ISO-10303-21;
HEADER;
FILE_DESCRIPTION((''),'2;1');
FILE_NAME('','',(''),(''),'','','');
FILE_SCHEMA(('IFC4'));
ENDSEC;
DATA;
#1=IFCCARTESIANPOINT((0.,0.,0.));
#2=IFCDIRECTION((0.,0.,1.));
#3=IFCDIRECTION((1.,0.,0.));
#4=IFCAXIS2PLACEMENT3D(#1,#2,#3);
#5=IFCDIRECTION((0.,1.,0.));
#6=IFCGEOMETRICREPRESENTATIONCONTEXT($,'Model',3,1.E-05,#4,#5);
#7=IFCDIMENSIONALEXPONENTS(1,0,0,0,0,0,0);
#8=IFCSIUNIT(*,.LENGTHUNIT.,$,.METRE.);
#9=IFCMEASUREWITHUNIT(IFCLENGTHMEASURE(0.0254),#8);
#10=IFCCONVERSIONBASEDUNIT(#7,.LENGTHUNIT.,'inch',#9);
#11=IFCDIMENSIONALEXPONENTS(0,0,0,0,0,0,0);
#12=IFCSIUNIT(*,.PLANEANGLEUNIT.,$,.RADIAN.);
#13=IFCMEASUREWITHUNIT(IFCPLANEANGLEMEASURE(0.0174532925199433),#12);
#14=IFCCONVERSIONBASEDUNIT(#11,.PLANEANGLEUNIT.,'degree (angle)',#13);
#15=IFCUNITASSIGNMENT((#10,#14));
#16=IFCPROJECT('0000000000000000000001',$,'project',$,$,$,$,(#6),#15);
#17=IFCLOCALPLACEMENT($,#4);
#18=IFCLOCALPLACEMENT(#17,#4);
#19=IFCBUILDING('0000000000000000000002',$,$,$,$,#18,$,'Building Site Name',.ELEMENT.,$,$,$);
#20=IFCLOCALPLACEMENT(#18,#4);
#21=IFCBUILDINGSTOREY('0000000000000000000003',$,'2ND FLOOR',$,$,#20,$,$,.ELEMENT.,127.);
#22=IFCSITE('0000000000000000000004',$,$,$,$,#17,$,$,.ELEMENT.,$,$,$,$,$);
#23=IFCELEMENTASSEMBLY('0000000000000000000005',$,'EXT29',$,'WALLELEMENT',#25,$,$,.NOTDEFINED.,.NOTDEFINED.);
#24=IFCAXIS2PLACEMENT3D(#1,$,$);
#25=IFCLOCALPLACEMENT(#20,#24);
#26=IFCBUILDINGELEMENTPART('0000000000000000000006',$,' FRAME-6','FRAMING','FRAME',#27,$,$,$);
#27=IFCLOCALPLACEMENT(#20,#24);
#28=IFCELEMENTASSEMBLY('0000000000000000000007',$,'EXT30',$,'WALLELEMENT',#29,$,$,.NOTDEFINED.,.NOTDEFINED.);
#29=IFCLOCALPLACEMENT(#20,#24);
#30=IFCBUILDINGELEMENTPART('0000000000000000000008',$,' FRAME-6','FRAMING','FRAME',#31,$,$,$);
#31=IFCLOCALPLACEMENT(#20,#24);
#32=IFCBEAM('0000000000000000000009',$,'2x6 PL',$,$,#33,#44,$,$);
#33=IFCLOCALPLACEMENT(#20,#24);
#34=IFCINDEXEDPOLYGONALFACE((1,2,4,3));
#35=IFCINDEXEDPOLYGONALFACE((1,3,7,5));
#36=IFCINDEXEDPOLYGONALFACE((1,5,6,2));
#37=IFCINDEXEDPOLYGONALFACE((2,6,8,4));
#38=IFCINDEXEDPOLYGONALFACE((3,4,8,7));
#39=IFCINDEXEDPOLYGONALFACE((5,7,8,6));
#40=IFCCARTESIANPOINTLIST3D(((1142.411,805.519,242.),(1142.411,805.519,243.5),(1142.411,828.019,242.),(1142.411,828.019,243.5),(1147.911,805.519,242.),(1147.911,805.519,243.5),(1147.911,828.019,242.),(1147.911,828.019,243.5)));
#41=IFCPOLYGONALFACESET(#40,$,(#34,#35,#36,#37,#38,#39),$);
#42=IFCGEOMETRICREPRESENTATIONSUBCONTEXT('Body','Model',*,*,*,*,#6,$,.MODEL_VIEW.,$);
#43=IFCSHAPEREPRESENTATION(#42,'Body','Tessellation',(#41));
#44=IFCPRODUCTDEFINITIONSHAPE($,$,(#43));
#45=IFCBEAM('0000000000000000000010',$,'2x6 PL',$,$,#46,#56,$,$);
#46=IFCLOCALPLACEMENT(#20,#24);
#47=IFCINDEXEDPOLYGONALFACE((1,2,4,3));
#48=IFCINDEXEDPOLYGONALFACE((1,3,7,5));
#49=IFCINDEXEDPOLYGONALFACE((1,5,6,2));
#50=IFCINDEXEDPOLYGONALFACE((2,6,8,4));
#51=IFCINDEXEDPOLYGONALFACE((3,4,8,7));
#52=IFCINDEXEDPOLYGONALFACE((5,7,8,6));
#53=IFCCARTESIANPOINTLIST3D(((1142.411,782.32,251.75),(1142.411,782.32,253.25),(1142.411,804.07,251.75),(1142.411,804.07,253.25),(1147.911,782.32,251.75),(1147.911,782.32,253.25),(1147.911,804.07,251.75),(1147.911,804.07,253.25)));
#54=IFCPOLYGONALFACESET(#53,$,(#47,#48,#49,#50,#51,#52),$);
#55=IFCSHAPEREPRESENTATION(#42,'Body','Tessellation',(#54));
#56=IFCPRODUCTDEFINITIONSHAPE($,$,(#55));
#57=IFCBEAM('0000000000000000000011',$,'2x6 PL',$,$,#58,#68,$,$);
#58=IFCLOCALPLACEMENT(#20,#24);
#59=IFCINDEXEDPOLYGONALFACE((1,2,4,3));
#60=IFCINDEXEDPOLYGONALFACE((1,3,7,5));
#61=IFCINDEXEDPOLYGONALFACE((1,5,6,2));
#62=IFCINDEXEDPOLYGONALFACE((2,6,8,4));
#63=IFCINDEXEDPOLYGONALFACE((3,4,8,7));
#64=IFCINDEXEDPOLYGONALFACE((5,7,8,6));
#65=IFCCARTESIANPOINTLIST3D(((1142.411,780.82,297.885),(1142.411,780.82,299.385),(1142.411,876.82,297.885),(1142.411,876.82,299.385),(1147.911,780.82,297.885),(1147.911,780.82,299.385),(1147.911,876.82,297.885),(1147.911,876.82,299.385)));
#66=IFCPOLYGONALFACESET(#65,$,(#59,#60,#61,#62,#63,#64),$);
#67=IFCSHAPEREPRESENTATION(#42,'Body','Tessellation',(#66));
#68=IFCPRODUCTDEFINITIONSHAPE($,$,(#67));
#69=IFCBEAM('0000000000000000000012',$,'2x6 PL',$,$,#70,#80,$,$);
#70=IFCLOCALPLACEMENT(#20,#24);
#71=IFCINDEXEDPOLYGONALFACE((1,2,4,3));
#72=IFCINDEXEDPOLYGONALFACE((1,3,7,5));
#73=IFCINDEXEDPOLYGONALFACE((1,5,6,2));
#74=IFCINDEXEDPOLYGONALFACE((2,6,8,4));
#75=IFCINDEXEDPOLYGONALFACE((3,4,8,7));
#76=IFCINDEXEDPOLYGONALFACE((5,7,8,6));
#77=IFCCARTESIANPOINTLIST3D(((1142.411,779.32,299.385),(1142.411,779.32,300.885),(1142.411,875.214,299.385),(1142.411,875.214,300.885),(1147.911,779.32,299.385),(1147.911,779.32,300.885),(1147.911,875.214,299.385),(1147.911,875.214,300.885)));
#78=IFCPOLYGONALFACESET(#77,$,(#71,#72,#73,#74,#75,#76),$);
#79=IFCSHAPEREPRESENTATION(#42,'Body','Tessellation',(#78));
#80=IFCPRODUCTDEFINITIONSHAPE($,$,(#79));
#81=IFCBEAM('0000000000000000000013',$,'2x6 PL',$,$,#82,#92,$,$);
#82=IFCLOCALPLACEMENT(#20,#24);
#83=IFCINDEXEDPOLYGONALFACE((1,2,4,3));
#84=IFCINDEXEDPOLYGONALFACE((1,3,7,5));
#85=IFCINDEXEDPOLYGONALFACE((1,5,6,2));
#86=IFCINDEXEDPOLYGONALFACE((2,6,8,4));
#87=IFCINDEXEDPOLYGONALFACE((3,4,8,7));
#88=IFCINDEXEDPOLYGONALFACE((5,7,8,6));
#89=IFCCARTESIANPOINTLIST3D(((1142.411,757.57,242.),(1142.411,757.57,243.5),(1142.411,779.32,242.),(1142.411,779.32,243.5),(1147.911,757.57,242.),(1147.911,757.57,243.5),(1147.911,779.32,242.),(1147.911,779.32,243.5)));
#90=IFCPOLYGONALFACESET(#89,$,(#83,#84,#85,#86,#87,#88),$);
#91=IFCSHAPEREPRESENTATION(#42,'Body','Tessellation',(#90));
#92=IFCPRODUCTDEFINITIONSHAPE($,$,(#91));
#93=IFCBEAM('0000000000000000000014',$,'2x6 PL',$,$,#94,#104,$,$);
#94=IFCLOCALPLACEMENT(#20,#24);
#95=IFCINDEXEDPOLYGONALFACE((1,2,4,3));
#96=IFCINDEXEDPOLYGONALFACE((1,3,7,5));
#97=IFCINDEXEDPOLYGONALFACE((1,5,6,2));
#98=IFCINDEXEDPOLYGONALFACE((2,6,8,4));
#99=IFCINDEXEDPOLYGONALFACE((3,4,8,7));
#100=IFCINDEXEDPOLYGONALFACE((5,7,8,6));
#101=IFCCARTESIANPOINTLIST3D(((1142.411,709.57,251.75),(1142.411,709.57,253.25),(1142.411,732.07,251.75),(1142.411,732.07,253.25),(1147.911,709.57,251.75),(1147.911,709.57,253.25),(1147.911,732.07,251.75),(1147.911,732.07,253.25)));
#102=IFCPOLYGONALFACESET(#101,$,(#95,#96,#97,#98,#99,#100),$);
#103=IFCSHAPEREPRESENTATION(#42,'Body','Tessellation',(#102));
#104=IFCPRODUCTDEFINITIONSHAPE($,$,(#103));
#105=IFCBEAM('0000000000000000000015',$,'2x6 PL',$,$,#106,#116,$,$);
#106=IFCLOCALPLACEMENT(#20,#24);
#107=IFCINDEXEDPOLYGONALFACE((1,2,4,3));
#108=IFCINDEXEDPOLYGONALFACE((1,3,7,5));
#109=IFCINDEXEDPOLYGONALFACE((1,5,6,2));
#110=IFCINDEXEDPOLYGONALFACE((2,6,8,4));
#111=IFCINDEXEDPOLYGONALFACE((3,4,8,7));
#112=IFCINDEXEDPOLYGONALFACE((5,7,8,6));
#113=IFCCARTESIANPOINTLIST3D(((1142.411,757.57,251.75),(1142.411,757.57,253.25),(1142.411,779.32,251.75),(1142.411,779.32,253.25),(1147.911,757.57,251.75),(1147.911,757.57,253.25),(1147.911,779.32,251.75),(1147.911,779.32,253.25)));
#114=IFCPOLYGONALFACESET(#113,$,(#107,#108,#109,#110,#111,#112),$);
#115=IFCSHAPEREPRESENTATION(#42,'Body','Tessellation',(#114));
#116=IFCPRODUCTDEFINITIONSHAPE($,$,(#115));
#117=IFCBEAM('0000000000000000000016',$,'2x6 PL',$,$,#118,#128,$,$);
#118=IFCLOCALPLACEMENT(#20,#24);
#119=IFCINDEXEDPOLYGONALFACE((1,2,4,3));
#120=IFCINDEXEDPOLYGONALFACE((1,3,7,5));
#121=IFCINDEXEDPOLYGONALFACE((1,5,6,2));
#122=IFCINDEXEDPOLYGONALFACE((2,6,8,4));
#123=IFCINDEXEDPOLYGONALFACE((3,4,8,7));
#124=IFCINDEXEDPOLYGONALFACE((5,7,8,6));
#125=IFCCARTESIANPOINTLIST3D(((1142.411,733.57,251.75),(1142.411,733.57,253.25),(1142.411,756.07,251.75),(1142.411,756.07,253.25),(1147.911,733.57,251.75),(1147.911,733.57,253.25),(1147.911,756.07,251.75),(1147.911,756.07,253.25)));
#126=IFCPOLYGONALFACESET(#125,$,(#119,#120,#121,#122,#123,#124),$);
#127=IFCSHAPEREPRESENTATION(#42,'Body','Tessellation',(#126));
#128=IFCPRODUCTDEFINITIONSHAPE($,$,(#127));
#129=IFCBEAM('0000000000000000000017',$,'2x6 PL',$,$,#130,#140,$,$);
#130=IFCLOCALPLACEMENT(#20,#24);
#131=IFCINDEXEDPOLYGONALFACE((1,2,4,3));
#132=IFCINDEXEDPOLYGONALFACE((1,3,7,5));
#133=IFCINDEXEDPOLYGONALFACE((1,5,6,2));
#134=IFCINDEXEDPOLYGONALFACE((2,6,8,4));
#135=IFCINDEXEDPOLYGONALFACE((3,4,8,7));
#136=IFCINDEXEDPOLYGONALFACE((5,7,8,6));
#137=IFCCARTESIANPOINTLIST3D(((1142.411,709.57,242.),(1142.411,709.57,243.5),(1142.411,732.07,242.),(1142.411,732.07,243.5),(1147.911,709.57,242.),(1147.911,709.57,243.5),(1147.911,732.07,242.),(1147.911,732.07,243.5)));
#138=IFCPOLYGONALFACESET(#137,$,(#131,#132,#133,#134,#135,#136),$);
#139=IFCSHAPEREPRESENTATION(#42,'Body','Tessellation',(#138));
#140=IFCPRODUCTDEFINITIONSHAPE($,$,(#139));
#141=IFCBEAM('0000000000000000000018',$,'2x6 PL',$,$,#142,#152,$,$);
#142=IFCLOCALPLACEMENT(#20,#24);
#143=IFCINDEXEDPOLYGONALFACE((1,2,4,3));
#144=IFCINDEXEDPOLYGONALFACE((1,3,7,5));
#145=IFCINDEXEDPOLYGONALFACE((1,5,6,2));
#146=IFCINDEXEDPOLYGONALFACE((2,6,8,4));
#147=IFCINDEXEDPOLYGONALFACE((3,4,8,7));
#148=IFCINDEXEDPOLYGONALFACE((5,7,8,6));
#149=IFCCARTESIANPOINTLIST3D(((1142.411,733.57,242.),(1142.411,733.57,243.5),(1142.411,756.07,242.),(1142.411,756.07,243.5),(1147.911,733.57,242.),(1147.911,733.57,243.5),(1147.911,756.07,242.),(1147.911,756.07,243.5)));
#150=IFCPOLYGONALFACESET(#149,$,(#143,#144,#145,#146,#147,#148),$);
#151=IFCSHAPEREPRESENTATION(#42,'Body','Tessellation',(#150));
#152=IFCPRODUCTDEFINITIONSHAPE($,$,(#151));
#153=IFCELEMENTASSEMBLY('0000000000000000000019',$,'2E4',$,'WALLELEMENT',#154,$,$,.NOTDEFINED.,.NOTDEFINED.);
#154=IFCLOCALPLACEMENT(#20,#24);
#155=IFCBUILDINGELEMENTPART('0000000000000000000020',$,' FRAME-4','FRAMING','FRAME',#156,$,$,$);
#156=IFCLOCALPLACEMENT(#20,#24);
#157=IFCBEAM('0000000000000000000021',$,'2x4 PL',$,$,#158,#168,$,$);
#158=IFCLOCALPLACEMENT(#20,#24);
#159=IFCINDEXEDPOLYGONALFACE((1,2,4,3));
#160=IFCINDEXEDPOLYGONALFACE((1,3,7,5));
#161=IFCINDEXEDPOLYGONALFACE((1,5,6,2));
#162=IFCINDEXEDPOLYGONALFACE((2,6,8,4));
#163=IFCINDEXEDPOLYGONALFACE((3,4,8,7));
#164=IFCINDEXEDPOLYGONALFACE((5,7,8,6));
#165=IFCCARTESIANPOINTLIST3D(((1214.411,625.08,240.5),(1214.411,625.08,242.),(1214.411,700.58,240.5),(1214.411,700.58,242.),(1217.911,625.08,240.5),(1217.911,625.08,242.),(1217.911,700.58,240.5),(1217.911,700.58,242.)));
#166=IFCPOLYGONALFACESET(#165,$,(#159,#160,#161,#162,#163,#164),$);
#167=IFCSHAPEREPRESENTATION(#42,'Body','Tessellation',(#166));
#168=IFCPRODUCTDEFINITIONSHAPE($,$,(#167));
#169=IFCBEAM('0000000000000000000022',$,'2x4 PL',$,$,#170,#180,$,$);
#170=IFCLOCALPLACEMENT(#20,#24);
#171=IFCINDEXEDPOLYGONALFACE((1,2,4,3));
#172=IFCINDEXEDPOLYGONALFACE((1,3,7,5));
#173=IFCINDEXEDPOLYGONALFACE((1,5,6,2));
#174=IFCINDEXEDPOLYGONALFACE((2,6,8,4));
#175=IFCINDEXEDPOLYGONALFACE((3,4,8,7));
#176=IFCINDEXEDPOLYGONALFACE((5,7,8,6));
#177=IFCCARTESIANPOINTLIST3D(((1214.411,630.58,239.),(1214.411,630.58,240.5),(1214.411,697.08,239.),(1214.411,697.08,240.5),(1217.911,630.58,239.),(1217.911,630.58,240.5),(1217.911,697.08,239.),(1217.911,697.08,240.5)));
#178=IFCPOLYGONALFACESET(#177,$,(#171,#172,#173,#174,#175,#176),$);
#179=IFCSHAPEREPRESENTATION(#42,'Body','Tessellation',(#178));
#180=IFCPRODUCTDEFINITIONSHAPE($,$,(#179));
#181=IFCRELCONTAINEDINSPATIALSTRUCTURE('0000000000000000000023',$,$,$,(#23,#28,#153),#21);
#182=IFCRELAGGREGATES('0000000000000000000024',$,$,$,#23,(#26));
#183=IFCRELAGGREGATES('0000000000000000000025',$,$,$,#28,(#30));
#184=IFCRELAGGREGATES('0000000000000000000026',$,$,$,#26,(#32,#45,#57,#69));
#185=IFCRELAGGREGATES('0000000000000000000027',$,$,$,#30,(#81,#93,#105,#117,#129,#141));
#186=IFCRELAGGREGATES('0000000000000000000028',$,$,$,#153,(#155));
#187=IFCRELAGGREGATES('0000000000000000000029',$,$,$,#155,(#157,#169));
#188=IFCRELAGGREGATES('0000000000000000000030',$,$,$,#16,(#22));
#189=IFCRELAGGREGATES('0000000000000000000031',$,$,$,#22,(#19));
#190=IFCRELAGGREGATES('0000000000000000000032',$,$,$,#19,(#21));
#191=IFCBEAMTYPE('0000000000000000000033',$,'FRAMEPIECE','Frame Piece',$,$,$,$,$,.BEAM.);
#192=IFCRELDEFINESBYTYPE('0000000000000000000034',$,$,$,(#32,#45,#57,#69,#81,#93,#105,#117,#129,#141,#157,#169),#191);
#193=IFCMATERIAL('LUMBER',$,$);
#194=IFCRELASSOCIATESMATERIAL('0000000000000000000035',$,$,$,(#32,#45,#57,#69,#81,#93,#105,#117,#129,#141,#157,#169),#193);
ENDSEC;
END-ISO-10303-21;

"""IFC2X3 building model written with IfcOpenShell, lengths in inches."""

from ifc_helpers import new_model, entity, si_unit, converted_unit, direction, frame, frame_2d, origin_with_axes, place, context, subcontext, project, spatial, rectangle, extrude, material, type_object, element, aggregate, save


model = new_model("IFC2X3")

# Units and contexts
model_context = context("Model", 3, precision=1e-05, world=origin_with_axes(), true_north=direction((0.0, 1.0, 0.0)))
body_context = subcontext(model_context, "Body", "Model", "MODEL_VIEW")
ifc_project = project(units=[converted_unit("LENGTHUNIT", "inch", entity("IfcLengthMeasure", 0.0254), si_unit("LENGTHUNIT", "METRE"), dimensions=[1, 0, 0, 0, 0, 0, 0]), converted_unit("PLANEANGLEUNIT", "degree (angle)", entity("IfcPlaneAngleMeasure", 0.0174532925199433), si_unit("PLANEANGLEUNIT", "RADIAN"), dimensions=[0, 0, 0, 0, 0, 0, 0])], contexts=[model_context])

# Site, building, storey
site_placement = place(None, origin_with_axes())
site = spatial("IfcSite", under=ifc_project, at=site_placement, CompositionType="ELEMENT")
building_placement = place(site_placement, origin_with_axes())
building = spatial("IfcBuilding", under=site, at=building_placement, LongName="Building Site Name", CompositionType="ELEMENT")
storey_placement = place(building_placement, origin_with_axes())
storey = spatial("IfcBuildingStorey", under=building, at=storey_placement, Name="2ND FLOOR", CompositionType="ELEMENT", Elevation=127.0)

# Element assembly, building element part
assembly_1_placement = place(storey_placement, origin_with_axes())
assembly_1 = element("IfcElementAssembly", 1, at=assembly_1_placement, inside=storey, Name="EXT29", ObjectType="WALLELEMENT", AssemblyPlace="NOTDEFINED", PredefinedType="NOTDEFINED")
building_element_part_1 = element("IfcBuildingElementPart", 2, Name=" FRAME-6", Description="FRAMING", ObjectType="FRAME")
aggregate(assembly_1, [building_element_part_1])
ifc_material = material(Name="LUMBER")
beam_type = type_object("IfcBeamType", Name="FRAMEPIECE", Description="Frame Piece", PredefinedType="BEAM")

# Element assembly, building element part
assembly_2_placement = place(storey_placement, origin_with_axes())
assembly_2 = element("IfcElementAssembly", 3, at=assembly_2_placement, inside=storey, Name="EXT30", ObjectType="WALLELEMENT", AssemblyPlace="NOTDEFINED", PredefinedType="NOTDEFINED")
building_element_part_2 = element("IfcBuildingElementPart", 4, Name=" FRAME-6", Description="FRAMING", ObjectType="FRAME")
aggregate(assembly_2, [building_element_part_2])

# Beams
beam_1_placement = place(assembly_1_placement, frame((1145.161, 805.519, 242.75), z_axis=(0.0, 1.0, 0.0), x_axis=(0.0, 0.0, -1.0)))
beam_1 = element("IfcBeam", 5, at=beam_1_placement, type_object=beam_type, material=ifc_material, Name="2x6 PL", context=body_context, shape_type="SweptSolid", body=[
    extrude(rectangle(XDim=1.5, YDim=5.5, at=frame_2d((0.0, 0.0), x_axis=(-1.0, 0.0))), origin_with_axes(), (0.0, 0.0, 1.0), 22.5),
])
beam_2_placement = place(assembly_1_placement, frame((1145.161, 782.32, 252.5), z_axis=(0.0, 1.0, 0.0), x_axis=(0.0, 0.0, -1.0)))
beam_2 = element("IfcBeam", 6, at=beam_2_placement, type_object=beam_type, material=ifc_material, Name="2x6 PL", context=body_context, shape_type="SweptSolid", body=[
    extrude(rectangle(XDim=1.5, YDim=5.5, at=frame_2d((0.0, 0.0), x_axis=(-1.0, 0.0))), origin_with_axes(), (0.0, 0.0, 1.0), 21.75),
])
beam_3_placement = place(assembly_1_placement, frame((1145.161, 780.82, 298.635), z_axis=(0.0, 1.0, 0.0), x_axis=(0.0, 0.0, -1.0)))
beam_3 = element("IfcBeam", 7, at=beam_3_placement, type_object=beam_type, material=ifc_material, Name="2x6 PL", context=body_context, shape_type="SweptSolid", body=[
    extrude(rectangle(XDim=1.5, YDim=5.5, at=frame_2d((0.0, 0.0), x_axis=(-1.0, 0.0))), origin_with_axes(), (0.0, 0.0, 1.0), 96.0),
])
beam_4_placement = place(assembly_1_placement, frame((1145.161, 779.32, 300.135), z_axis=(0.0, 1.0, 0.0), x_axis=(0.0, 0.0, -1.0)))
beam_4 = element("IfcBeam", 8, at=beam_4_placement, type_object=beam_type, material=ifc_material, Name="2x6 PL", context=body_context, shape_type="SweptSolid", body=[
    extrude(rectangle(XDim=1.5, YDim=5.5, at=frame_2d((0.0, 0.0), x_axis=(-1.0, 0.0))), origin_with_axes(), (0.0, 0.0, 1.0), 95.894),
])
aggregate(building_element_part_1, [beam_1, beam_2, beam_3, beam_4])
beam_5_placement = place(assembly_2_placement, frame((1145.161, 757.57, 242.75), z_axis=(0.0, 1.0, 0.0), x_axis=(0.0, 0.0, -1.0)))
beam_5 = element("IfcBeam", 9, at=beam_5_placement, type_object=beam_type, material=ifc_material, Name="2x6 PL", context=body_context, shape_type="SweptSolid", body=[
    extrude(rectangle(XDim=1.5, YDim=5.5, at=frame_2d((0.0, 0.0), x_axis=(-1.0, 0.0))), origin_with_axes(), (0.0, 0.0, 1.0), 21.75),
])
beam_6_placement = place(assembly_2_placement, frame((1145.161, 709.57, 252.5), z_axis=(0.0, 1.0, 0.0), x_axis=(0.0, 0.0, -1.0)))
beam_6 = element("IfcBeam", 10, at=beam_6_placement, type_object=beam_type, material=ifc_material, Name="2x6 PL", context=body_context, shape_type="SweptSolid", body=[
    extrude(rectangle(XDim=1.5, YDim=5.5, at=frame_2d((0.0, 0.0), x_axis=(-1.0, 0.0))), origin_with_axes(), (0.0, 0.0, 1.0), 22.5),
])
beam_7_placement = place(assembly_2_placement, frame((1145.161, 757.57, 252.5), z_axis=(0.0, 1.0, 0.0), x_axis=(0.0, 0.0, -1.0)))
beam_7 = element("IfcBeam", 11, at=beam_7_placement, type_object=beam_type, material=ifc_material, Name="2x6 PL", context=body_context, shape_type="SweptSolid", body=[
    extrude(rectangle(XDim=1.5, YDim=5.5, at=frame_2d((0.0, 0.0), x_axis=(-1.0, 0.0))), origin_with_axes(), (0.0, 0.0, 1.0), 21.75),
])
beam_8_placement = place(assembly_2_placement, frame((1145.161, 733.57, 252.5), z_axis=(0.0, 1.0, 0.0), x_axis=(0.0, 0.0, -1.0)))
beam_8 = element("IfcBeam", 12, at=beam_8_placement, type_object=beam_type, material=ifc_material, Name="2x6 PL", context=body_context, shape_type="SweptSolid", body=[
    extrude(rectangle(XDim=1.5, YDim=5.5, at=frame_2d((0.0, 0.0), x_axis=(-1.0, 0.0))), origin_with_axes(), (0.0, 0.0, 1.0), 22.5),
])
beam_9_placement = place(assembly_2_placement, frame((1145.161, 709.57, 242.75), z_axis=(0.0, 1.0, 0.0), x_axis=(0.0, 0.0, -1.0)))
beam_9 = element("IfcBeam", 13, at=beam_9_placement, type_object=beam_type, material=ifc_material, Name="2x6 PL", context=body_context, shape_type="SweptSolid", body=[
    extrude(rectangle(XDim=1.5, YDim=5.5, at=frame_2d((0.0, 0.0), x_axis=(-1.0, 0.0))), origin_with_axes(), (0.0, 0.0, 1.0), 22.5),
])
beam_10_placement = place(assembly_2_placement, frame((1145.161, 733.57, 242.75), z_axis=(0.0, 1.0, 0.0), x_axis=(0.0, 0.0, -1.0)))
beam_10 = element("IfcBeam", 14, at=beam_10_placement, type_object=beam_type, material=ifc_material, Name="2x6 PL", context=body_context, shape_type="SweptSolid", body=[
    extrude(rectangle(XDim=1.5, YDim=5.5, at=frame_2d((0.0, 0.0), x_axis=(-1.0, 0.0))), origin_with_axes(), (0.0, 0.0, 1.0), 22.5),
])
aggregate(building_element_part_2, [beam_5, beam_6, beam_7, beam_8, beam_9, beam_10])

# Element assembly, building element part, beams
assembly_3_placement = place(storey_placement, origin_with_axes())
assembly_3 = element("IfcElementAssembly", 15, at=assembly_3_placement, inside=storey, Name="2E4", ObjectType="WALLELEMENT", AssemblyPlace="NOTDEFINED", PredefinedType="NOTDEFINED")
building_element_part_3 = element("IfcBuildingElementPart", 16, Name=" FRAME-4", Description="FRAMING", ObjectType="FRAME")
aggregate(assembly_3, [building_element_part_3])
beam_11_placement = place(assembly_3_placement, frame((1216.161, 700.58, 241.25), z_axis=(0.0, -1.0, 0.0), x_axis=(0.0, 0.0, -1.0)))
beam_11 = element("IfcBeam", 17, at=beam_11_placement, type_object=beam_type, material=ifc_material, Name="2x4 PL", context=body_context, shape_type="SweptSolid", body=[
    extrude(rectangle(XDim=1.5, YDim=3.5, at=frame_2d((0.0, 0.0), x_axis=(-1.0, 0.0))), origin_with_axes(), (0.0, 0.0, 1.0), 75.5),
])
beam_12_placement = place(assembly_3_placement, frame((1216.161, 697.08, 239.75), z_axis=(0.0, -1.0, 0.0), x_axis=(0.0, 0.0, -1.0)))
beam_12 = element("IfcBeam", 18, at=beam_12_placement, type_object=beam_type, material=ifc_material, Name="2x4 PL", context=body_context, shape_type="SweptSolid", body=[
    extrude(rectangle(XDim=1.5, YDim=3.5, at=frame_2d((0.0, 0.0), x_axis=(-1.0, 0.0))), origin_with_axes(), (0.0, 0.0, 1.0), 66.5),
])
aggregate(building_element_part_3, [beam_11, beam_12])

save(model, "model.ifc")
